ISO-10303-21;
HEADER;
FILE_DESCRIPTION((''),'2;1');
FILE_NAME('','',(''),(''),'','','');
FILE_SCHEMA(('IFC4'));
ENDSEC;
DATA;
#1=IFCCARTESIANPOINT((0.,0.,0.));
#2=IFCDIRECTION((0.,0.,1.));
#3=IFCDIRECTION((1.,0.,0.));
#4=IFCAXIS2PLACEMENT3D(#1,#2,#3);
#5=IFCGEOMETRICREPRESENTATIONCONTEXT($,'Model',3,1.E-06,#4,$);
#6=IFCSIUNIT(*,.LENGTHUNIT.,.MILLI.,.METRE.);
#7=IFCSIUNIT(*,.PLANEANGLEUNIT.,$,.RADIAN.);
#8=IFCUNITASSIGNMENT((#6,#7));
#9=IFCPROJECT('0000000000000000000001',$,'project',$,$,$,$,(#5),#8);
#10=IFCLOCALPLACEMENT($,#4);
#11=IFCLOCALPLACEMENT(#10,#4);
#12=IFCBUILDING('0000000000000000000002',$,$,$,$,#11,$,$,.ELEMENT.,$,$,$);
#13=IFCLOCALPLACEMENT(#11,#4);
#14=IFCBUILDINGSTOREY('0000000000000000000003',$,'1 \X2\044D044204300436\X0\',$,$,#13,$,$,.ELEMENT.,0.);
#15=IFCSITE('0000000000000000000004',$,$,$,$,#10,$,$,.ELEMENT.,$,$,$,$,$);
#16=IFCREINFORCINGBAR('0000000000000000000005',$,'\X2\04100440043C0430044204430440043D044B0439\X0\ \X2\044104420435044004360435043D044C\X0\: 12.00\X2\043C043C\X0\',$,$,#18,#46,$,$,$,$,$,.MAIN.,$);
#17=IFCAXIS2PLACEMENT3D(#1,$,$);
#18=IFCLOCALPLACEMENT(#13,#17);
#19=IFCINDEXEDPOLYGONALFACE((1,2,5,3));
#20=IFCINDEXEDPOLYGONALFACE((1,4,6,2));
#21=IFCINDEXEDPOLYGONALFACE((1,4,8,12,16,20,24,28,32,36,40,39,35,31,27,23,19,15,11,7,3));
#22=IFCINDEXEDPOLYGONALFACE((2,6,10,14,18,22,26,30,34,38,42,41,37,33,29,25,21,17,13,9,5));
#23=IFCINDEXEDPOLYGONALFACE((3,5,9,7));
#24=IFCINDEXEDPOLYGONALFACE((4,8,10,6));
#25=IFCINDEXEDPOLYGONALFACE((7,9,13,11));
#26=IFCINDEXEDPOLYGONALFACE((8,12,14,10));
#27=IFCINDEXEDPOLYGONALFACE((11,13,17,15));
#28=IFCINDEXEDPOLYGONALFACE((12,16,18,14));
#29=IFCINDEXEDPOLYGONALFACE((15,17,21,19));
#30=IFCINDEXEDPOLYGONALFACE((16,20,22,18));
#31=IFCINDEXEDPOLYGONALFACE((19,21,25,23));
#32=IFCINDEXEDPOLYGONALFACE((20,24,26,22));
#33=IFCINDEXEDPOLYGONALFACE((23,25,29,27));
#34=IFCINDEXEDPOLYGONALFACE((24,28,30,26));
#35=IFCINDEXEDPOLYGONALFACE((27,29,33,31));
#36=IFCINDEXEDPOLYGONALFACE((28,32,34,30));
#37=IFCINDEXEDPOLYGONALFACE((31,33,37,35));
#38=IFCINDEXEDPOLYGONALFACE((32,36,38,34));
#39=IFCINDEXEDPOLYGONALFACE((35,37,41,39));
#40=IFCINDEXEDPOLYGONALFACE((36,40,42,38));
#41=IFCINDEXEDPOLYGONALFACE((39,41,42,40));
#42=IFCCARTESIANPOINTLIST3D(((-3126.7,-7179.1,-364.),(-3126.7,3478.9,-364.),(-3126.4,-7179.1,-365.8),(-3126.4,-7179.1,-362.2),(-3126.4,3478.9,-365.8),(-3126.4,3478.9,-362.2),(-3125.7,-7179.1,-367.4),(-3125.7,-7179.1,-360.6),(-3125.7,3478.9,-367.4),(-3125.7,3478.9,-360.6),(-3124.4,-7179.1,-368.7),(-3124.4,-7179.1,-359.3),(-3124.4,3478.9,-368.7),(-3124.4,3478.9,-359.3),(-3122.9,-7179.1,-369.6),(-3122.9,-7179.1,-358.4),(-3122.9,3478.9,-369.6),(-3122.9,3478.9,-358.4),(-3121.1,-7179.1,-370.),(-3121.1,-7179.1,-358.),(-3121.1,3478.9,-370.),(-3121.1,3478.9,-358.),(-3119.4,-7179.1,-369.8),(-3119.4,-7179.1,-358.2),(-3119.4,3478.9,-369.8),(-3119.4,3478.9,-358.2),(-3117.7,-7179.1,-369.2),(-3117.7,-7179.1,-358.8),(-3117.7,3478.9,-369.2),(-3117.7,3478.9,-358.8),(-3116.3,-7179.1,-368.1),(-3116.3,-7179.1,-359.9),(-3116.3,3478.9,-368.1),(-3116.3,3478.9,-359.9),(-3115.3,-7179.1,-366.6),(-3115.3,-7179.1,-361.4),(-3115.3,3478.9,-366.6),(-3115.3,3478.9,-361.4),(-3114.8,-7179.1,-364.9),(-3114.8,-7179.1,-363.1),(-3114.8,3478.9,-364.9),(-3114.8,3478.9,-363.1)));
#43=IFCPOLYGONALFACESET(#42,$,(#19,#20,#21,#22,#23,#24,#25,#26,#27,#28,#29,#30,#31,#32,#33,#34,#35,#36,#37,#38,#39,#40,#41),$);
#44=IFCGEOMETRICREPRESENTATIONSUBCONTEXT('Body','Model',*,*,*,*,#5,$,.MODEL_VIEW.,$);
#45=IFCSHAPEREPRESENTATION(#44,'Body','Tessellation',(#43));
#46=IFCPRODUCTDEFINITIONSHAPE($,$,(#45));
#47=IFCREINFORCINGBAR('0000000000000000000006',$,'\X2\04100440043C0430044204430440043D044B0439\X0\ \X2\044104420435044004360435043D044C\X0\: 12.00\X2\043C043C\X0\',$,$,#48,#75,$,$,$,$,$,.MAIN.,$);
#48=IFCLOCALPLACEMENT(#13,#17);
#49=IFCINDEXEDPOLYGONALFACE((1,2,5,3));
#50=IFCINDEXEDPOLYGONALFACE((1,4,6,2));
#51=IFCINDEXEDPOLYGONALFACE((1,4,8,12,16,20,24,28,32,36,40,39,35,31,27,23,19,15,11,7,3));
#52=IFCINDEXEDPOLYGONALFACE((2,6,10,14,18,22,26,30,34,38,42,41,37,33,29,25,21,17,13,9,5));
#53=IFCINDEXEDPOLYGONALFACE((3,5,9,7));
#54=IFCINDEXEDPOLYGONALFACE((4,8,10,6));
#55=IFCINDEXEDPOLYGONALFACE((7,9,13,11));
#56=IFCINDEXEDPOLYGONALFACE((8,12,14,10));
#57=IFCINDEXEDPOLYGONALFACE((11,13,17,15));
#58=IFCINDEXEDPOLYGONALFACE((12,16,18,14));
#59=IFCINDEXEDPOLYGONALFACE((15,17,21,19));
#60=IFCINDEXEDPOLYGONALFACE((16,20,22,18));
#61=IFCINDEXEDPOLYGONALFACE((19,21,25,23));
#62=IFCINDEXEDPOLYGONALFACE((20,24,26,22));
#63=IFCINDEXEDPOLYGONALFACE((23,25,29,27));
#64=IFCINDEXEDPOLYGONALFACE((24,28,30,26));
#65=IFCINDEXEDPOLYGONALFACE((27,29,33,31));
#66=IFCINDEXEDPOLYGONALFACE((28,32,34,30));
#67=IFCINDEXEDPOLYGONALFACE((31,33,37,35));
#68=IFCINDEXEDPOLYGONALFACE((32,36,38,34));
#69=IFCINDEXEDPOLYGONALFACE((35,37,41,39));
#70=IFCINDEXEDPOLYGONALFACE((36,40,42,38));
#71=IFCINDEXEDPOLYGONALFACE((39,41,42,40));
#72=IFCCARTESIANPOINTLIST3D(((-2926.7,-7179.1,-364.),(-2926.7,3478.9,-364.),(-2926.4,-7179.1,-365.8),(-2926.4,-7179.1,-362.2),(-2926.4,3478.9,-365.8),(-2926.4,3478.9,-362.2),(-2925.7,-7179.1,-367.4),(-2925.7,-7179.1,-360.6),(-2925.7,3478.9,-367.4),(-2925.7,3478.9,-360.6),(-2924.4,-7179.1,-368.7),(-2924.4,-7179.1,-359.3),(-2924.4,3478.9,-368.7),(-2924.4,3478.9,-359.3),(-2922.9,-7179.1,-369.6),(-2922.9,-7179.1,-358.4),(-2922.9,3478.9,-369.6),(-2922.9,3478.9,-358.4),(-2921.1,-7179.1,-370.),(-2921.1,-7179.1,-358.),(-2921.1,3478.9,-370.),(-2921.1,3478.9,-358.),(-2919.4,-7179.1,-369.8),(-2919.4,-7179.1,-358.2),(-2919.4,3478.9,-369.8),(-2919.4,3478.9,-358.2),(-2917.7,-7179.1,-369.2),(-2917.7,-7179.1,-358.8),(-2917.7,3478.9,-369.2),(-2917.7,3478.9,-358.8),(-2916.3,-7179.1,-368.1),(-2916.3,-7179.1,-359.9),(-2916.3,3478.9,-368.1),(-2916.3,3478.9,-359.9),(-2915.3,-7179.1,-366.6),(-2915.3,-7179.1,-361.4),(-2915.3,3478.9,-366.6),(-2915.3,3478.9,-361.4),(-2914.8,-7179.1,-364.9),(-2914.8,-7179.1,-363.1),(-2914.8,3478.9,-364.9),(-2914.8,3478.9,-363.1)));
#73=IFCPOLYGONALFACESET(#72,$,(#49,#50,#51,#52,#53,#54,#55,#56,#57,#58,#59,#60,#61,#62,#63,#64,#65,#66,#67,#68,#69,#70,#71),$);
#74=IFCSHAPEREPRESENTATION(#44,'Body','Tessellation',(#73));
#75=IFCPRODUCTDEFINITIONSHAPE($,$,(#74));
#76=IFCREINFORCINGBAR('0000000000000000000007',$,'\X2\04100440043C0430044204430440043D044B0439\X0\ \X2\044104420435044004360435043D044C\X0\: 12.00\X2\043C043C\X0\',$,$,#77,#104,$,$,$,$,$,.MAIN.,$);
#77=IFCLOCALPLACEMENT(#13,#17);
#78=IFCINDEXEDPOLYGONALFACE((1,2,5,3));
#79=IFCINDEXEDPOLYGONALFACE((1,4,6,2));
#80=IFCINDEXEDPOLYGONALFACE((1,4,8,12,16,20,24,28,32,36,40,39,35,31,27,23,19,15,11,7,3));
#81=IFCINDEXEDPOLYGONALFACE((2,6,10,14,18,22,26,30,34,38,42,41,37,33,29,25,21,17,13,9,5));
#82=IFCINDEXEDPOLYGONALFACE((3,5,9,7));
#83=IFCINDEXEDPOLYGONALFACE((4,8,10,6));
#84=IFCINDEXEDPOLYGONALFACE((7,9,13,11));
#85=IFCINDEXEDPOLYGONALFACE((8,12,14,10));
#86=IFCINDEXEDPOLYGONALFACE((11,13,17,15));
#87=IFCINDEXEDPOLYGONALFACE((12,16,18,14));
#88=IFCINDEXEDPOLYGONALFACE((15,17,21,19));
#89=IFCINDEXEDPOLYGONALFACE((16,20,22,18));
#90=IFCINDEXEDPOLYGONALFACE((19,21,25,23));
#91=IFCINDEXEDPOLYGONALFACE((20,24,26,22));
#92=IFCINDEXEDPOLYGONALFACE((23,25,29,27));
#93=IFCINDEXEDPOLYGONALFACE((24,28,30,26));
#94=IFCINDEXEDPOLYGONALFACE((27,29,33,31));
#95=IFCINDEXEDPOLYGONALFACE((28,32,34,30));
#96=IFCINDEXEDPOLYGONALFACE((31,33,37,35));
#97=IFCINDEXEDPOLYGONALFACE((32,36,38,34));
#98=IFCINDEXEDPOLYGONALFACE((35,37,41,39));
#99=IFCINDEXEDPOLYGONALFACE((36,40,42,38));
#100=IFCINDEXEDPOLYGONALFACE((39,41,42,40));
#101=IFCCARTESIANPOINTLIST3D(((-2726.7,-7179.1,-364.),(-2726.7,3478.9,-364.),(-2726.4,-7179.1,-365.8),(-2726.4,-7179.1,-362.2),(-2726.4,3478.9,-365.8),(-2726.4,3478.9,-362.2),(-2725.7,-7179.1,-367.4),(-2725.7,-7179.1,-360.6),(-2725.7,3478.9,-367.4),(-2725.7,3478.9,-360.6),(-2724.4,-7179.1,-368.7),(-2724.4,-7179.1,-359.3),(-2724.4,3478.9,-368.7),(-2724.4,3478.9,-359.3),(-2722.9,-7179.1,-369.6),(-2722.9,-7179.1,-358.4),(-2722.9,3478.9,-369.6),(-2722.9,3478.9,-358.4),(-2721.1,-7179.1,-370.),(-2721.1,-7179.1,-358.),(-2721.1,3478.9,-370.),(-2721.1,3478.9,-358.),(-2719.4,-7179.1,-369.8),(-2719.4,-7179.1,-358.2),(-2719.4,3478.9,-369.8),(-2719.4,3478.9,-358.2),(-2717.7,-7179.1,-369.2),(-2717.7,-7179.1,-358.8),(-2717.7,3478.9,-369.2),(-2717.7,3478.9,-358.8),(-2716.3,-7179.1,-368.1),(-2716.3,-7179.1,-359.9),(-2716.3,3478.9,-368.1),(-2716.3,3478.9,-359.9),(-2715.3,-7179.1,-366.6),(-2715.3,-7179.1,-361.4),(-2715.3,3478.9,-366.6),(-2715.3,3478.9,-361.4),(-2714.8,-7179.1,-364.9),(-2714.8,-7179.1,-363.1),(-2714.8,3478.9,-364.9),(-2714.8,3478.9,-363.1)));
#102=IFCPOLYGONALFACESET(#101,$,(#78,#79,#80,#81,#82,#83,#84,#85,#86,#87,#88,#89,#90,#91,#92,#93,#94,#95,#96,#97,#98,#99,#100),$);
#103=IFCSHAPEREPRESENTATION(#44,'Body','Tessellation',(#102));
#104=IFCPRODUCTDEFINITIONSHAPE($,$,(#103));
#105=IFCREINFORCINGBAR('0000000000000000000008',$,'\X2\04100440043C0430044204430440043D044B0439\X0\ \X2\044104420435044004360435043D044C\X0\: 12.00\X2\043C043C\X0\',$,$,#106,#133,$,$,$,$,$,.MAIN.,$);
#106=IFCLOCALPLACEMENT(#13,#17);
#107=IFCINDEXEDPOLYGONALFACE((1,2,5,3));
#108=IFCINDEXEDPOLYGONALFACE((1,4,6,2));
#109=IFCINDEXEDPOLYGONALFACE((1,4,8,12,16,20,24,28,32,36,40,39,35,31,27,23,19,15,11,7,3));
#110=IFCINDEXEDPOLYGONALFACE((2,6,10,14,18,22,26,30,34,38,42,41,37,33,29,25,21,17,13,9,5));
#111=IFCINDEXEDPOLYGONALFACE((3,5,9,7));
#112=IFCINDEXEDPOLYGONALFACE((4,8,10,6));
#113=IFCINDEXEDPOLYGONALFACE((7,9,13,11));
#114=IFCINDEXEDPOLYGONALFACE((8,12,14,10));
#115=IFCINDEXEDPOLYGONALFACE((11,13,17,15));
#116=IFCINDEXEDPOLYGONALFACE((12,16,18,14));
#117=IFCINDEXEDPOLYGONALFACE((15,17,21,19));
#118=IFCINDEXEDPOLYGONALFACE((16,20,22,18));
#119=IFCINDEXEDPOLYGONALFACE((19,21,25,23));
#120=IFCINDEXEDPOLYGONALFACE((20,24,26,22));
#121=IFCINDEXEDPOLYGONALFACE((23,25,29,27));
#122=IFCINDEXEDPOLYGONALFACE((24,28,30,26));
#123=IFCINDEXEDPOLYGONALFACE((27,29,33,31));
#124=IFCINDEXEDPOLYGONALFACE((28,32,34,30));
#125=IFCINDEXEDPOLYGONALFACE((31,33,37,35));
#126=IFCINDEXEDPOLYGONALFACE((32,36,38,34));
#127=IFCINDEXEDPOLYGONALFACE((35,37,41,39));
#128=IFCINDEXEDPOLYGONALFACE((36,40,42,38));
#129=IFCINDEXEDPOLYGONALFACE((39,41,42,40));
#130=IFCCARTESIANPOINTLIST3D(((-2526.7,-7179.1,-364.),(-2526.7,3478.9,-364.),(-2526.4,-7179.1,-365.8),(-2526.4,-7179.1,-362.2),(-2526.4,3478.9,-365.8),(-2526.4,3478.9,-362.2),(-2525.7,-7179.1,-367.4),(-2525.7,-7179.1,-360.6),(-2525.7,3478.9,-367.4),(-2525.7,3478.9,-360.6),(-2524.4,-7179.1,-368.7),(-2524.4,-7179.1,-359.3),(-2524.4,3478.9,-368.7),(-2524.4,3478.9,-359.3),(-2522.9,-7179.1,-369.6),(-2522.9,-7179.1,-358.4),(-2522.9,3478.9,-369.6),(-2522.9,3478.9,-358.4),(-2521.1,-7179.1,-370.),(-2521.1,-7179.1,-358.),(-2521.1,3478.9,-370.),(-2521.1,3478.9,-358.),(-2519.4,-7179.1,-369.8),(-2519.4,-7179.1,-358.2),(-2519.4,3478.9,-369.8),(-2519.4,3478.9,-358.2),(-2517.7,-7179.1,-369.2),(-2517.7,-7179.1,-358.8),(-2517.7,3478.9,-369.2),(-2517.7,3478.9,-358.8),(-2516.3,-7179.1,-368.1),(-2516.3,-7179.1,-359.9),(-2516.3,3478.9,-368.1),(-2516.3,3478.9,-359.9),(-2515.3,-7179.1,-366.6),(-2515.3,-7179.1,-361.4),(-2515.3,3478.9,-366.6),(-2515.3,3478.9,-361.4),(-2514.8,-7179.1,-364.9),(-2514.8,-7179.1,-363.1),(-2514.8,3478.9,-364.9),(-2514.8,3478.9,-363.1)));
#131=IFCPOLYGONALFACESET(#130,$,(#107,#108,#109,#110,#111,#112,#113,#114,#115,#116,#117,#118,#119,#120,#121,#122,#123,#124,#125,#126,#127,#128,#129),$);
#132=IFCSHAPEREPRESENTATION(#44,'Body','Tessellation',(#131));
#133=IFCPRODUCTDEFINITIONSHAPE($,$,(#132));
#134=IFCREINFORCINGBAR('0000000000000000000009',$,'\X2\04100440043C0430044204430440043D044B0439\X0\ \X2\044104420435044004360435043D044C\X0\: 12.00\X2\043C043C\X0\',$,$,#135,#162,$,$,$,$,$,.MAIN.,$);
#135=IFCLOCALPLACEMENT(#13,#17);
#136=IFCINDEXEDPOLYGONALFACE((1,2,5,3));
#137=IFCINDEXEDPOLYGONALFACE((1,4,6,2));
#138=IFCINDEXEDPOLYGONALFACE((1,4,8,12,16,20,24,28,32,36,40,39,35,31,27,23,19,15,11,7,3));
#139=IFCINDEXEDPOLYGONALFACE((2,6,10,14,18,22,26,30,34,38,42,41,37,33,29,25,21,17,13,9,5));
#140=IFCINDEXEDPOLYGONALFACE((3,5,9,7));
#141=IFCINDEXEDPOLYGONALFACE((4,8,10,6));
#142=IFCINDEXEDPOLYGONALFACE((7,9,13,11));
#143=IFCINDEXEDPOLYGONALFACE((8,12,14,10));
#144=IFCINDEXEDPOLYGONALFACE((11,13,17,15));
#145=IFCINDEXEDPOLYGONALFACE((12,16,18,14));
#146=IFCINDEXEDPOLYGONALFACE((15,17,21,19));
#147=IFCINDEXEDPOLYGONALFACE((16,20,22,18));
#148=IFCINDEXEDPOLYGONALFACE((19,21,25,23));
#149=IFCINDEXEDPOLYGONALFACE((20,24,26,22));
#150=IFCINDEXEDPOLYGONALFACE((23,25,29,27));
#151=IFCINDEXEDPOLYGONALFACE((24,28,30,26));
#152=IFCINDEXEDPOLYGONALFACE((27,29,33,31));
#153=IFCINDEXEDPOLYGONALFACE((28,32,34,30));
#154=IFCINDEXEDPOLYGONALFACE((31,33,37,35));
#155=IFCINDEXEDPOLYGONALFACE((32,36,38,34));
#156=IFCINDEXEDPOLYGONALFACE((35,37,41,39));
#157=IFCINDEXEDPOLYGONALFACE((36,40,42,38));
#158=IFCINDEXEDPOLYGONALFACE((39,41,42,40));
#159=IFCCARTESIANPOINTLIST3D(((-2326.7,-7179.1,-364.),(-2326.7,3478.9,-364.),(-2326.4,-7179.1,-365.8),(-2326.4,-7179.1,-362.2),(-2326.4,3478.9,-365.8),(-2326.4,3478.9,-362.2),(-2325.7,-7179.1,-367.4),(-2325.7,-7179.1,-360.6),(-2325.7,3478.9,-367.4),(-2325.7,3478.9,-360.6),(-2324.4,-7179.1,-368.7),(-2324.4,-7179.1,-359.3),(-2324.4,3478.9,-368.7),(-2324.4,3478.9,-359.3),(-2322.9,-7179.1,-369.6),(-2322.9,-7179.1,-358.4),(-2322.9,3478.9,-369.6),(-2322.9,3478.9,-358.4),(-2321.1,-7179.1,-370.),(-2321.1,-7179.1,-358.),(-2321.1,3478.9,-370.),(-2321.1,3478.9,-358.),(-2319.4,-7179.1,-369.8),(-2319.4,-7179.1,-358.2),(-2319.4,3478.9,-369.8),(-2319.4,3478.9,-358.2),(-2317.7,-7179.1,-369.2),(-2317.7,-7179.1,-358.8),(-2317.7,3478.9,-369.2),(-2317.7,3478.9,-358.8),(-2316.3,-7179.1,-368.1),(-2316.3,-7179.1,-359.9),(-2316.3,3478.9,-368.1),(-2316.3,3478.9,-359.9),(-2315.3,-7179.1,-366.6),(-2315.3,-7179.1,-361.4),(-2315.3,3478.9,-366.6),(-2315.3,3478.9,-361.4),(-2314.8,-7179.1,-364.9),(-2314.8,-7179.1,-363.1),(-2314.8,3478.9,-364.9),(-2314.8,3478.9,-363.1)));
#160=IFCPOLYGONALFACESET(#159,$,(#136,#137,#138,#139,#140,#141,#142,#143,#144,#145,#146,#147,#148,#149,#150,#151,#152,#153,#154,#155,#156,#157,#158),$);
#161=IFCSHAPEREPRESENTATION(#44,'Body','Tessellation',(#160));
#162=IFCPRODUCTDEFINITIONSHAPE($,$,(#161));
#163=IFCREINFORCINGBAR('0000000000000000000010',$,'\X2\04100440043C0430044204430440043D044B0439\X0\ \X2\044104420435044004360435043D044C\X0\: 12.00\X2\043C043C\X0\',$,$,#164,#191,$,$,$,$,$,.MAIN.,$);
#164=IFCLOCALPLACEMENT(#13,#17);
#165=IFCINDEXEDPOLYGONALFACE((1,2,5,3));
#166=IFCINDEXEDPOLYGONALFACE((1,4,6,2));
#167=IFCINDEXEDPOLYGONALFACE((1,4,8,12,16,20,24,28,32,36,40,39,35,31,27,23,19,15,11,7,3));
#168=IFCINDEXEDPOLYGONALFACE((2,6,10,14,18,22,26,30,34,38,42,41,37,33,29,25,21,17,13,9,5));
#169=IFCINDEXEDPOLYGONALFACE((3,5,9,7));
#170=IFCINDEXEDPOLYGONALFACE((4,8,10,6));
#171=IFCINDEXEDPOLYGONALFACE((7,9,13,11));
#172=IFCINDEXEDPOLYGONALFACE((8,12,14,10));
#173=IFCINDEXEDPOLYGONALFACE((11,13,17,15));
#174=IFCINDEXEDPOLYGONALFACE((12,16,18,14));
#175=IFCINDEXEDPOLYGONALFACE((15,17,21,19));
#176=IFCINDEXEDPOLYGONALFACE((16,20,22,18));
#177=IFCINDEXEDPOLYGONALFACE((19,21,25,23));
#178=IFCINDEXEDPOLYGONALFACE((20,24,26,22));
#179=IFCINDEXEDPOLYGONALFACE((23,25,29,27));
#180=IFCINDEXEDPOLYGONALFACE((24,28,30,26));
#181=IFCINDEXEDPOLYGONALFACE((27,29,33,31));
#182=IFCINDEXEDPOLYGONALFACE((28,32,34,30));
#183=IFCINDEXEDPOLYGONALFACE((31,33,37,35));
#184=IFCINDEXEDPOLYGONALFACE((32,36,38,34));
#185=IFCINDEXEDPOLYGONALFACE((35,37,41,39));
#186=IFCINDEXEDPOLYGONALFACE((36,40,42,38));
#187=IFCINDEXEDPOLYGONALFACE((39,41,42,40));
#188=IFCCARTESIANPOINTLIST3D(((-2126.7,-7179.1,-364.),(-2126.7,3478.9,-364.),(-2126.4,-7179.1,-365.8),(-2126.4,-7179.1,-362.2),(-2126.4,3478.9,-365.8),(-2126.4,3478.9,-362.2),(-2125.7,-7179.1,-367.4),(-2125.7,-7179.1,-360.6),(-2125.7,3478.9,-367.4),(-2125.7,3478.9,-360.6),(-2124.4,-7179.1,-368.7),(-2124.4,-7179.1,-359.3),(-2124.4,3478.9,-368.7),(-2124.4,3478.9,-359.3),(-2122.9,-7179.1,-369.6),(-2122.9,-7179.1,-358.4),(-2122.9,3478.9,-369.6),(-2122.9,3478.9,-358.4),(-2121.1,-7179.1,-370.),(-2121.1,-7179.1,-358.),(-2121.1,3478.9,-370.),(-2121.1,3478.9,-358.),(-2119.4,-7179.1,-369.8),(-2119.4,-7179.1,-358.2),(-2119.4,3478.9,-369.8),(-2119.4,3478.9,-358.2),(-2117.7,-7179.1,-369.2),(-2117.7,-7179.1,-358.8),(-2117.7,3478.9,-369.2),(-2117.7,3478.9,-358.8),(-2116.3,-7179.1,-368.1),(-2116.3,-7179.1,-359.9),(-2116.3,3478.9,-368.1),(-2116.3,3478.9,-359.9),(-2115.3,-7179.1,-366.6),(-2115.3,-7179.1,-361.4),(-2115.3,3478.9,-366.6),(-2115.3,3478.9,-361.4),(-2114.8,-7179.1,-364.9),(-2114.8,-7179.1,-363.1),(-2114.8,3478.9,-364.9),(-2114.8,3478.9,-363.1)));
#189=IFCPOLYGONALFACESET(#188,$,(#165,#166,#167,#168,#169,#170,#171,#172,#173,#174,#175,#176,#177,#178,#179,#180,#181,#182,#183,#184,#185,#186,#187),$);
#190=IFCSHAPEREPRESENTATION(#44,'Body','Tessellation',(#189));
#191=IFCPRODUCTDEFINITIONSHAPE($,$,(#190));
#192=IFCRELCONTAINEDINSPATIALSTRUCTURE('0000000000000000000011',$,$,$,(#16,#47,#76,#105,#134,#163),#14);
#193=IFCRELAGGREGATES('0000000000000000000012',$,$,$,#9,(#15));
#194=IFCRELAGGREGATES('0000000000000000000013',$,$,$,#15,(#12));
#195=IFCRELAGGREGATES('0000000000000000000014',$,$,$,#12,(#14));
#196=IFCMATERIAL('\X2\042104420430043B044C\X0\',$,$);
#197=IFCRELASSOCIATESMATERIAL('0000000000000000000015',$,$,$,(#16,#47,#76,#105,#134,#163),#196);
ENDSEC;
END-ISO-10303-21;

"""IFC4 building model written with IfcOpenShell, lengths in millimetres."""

from ifc_helpers import new_model, entity, si_unit, origin_with_axes, place, context, subcontext, project, spatial, source, transform, mapped, material, element, save


model = new_model("IFC4")

# Units and contexts
model_context = context("Model", 3, precision=1e-06, world=origin_with_axes())
body_context = subcontext(model_context, "Body", "Model", "MODEL_VIEW")
ifc_project = project(units=[si_unit("LENGTHUNIT", "METRE", prefix="MILLI"), si_unit("PLANEANGLEUNIT", "RADIAN")], contexts=[model_context])

# Site, building, storey
site_placement = place(None, origin_with_axes())
site = spatial("IfcSite", under=ifc_project, at=site_placement, CompositionType="ELEMENT")
building_placement = place(site_placement, origin_with_axes())
building = spatial("IfcBuilding", under=site, at=building_placement, CompositionType="ELEMENT")
storey_placement = place(building_placement, origin_with_axes())
storey = spatial("IfcBuildingStorey", under=building, at=storey_placement, Name="1 этаж", CompositionType="ELEMENT", Elevation=0.0)

# Reinforcing bars
ifc_material = material(Name="Сталь")
shared_shape_1 = source(origin_with_axes(), body_context, "Body", "AdvancedSweptSolid", [
    entity("IfcSweptDiskSolid", entity("IfcIndexedPolyCurve", entity("IfcCartesianPointList3D", [[0.0, 0.0, 0.0], [10658.0, 0.0, 0.0]]), [entity("IfcLineIndex", [1, 2])]), 6.0),
])
reinforcing_bar_1_placement = place(storey_placement, origin_with_axes())
element("IfcReinforcingBar", 1, at=reinforcing_bar_1_placement, inside=storey, material=ifc_material, Name="Арматурный стержень: 12.00мм", PredefinedType="MAIN", context=body_context, shape_type="MappedRepresentation", body=[
    mapped(shared_shape_1, transform((-3120.7, -7179.1, -364.0), x_axis=(0.0, 1.0, 0.0), y_axis=(-1.0, 0.0, 0.0), z_axis=(0.0, 0.0, 1.0), scale=1.0)),
])
reinforcing_bar_2_placement = place(storey_placement, origin_with_axes())
element("IfcReinforcingBar", 2, at=reinforcing_bar_2_placement, inside=storey, material=ifc_material, Name="Арматурный стержень: 12.00мм", PredefinedType="MAIN", context=body_context, shape_type="MappedRepresentation", body=[
    mapped(shared_shape_1, transform((-2920.7, -7179.1, -364.0), x_axis=(0.0, 1.0, 0.0), y_axis=(-1.0, 0.0, 0.0), z_axis=(0.0, 0.0, 1.0), scale=1.0)),
])
reinforcing_bar_3_placement = place(storey_placement, origin_with_axes())
element("IfcReinforcingBar", 3, at=reinforcing_bar_3_placement, inside=storey, material=ifc_material, Name="Арматурный стержень: 12.00мм", PredefinedType="MAIN", context=body_context, shape_type="MappedRepresentation", body=[
    mapped(shared_shape_1, transform((-2720.7, -7179.1, -364.0), x_axis=(0.0, 1.0, 0.0), y_axis=(-1.0, 0.0, 0.0), z_axis=(0.0, 0.0, 1.0), scale=1.0)),
])
reinforcing_bar_4_placement = place(storey_placement, origin_with_axes())
element("IfcReinforcingBar", 4, at=reinforcing_bar_4_placement, inside=storey, material=ifc_material, Name="Арматурный стержень: 12.00мм", PredefinedType="MAIN", context=body_context, shape_type="MappedRepresentation", body=[
    mapped(shared_shape_1, transform((-2520.7, -7179.1, -364.0), x_axis=(0.0, 1.0, 0.0), y_axis=(-1.0, 0.0, 0.0), z_axis=(0.0, 0.0, 1.0), scale=1.0)),
])
reinforcing_bar_5_placement = place(storey_placement, origin_with_axes())
element("IfcReinforcingBar", 5, at=reinforcing_bar_5_placement, inside=storey, material=ifc_material, Name="Арматурный стержень: 12.00мм", PredefinedType="MAIN", context=body_context, shape_type="MappedRepresentation", body=[
    mapped(shared_shape_1, transform((-2320.7, -7179.1, -364.0), x_axis=(0.0, 1.0, 0.0), y_axis=(-1.0, 0.0, 0.0), z_axis=(0.0, 0.0, 1.0), scale=1.0)),
])
reinforcing_bar_6_placement = place(storey_placement, origin_with_axes())
element("IfcReinforcingBar", 6, at=reinforcing_bar_6_placement, inside=storey, material=ifc_material, Name="Арматурный стержень: 12.00мм", PredefinedType="MAIN", context=body_context, shape_type="MappedRepresentation", body=[
    mapped(shared_shape_1, transform((-2120.7, -7179.1, -364.0), x_axis=(0.0, 1.0, 0.0), y_axis=(-1.0, 0.0, 0.0), z_axis=(0.0, 0.0, 1.0), scale=1.0)),
])

save(model, "model.ifc")
